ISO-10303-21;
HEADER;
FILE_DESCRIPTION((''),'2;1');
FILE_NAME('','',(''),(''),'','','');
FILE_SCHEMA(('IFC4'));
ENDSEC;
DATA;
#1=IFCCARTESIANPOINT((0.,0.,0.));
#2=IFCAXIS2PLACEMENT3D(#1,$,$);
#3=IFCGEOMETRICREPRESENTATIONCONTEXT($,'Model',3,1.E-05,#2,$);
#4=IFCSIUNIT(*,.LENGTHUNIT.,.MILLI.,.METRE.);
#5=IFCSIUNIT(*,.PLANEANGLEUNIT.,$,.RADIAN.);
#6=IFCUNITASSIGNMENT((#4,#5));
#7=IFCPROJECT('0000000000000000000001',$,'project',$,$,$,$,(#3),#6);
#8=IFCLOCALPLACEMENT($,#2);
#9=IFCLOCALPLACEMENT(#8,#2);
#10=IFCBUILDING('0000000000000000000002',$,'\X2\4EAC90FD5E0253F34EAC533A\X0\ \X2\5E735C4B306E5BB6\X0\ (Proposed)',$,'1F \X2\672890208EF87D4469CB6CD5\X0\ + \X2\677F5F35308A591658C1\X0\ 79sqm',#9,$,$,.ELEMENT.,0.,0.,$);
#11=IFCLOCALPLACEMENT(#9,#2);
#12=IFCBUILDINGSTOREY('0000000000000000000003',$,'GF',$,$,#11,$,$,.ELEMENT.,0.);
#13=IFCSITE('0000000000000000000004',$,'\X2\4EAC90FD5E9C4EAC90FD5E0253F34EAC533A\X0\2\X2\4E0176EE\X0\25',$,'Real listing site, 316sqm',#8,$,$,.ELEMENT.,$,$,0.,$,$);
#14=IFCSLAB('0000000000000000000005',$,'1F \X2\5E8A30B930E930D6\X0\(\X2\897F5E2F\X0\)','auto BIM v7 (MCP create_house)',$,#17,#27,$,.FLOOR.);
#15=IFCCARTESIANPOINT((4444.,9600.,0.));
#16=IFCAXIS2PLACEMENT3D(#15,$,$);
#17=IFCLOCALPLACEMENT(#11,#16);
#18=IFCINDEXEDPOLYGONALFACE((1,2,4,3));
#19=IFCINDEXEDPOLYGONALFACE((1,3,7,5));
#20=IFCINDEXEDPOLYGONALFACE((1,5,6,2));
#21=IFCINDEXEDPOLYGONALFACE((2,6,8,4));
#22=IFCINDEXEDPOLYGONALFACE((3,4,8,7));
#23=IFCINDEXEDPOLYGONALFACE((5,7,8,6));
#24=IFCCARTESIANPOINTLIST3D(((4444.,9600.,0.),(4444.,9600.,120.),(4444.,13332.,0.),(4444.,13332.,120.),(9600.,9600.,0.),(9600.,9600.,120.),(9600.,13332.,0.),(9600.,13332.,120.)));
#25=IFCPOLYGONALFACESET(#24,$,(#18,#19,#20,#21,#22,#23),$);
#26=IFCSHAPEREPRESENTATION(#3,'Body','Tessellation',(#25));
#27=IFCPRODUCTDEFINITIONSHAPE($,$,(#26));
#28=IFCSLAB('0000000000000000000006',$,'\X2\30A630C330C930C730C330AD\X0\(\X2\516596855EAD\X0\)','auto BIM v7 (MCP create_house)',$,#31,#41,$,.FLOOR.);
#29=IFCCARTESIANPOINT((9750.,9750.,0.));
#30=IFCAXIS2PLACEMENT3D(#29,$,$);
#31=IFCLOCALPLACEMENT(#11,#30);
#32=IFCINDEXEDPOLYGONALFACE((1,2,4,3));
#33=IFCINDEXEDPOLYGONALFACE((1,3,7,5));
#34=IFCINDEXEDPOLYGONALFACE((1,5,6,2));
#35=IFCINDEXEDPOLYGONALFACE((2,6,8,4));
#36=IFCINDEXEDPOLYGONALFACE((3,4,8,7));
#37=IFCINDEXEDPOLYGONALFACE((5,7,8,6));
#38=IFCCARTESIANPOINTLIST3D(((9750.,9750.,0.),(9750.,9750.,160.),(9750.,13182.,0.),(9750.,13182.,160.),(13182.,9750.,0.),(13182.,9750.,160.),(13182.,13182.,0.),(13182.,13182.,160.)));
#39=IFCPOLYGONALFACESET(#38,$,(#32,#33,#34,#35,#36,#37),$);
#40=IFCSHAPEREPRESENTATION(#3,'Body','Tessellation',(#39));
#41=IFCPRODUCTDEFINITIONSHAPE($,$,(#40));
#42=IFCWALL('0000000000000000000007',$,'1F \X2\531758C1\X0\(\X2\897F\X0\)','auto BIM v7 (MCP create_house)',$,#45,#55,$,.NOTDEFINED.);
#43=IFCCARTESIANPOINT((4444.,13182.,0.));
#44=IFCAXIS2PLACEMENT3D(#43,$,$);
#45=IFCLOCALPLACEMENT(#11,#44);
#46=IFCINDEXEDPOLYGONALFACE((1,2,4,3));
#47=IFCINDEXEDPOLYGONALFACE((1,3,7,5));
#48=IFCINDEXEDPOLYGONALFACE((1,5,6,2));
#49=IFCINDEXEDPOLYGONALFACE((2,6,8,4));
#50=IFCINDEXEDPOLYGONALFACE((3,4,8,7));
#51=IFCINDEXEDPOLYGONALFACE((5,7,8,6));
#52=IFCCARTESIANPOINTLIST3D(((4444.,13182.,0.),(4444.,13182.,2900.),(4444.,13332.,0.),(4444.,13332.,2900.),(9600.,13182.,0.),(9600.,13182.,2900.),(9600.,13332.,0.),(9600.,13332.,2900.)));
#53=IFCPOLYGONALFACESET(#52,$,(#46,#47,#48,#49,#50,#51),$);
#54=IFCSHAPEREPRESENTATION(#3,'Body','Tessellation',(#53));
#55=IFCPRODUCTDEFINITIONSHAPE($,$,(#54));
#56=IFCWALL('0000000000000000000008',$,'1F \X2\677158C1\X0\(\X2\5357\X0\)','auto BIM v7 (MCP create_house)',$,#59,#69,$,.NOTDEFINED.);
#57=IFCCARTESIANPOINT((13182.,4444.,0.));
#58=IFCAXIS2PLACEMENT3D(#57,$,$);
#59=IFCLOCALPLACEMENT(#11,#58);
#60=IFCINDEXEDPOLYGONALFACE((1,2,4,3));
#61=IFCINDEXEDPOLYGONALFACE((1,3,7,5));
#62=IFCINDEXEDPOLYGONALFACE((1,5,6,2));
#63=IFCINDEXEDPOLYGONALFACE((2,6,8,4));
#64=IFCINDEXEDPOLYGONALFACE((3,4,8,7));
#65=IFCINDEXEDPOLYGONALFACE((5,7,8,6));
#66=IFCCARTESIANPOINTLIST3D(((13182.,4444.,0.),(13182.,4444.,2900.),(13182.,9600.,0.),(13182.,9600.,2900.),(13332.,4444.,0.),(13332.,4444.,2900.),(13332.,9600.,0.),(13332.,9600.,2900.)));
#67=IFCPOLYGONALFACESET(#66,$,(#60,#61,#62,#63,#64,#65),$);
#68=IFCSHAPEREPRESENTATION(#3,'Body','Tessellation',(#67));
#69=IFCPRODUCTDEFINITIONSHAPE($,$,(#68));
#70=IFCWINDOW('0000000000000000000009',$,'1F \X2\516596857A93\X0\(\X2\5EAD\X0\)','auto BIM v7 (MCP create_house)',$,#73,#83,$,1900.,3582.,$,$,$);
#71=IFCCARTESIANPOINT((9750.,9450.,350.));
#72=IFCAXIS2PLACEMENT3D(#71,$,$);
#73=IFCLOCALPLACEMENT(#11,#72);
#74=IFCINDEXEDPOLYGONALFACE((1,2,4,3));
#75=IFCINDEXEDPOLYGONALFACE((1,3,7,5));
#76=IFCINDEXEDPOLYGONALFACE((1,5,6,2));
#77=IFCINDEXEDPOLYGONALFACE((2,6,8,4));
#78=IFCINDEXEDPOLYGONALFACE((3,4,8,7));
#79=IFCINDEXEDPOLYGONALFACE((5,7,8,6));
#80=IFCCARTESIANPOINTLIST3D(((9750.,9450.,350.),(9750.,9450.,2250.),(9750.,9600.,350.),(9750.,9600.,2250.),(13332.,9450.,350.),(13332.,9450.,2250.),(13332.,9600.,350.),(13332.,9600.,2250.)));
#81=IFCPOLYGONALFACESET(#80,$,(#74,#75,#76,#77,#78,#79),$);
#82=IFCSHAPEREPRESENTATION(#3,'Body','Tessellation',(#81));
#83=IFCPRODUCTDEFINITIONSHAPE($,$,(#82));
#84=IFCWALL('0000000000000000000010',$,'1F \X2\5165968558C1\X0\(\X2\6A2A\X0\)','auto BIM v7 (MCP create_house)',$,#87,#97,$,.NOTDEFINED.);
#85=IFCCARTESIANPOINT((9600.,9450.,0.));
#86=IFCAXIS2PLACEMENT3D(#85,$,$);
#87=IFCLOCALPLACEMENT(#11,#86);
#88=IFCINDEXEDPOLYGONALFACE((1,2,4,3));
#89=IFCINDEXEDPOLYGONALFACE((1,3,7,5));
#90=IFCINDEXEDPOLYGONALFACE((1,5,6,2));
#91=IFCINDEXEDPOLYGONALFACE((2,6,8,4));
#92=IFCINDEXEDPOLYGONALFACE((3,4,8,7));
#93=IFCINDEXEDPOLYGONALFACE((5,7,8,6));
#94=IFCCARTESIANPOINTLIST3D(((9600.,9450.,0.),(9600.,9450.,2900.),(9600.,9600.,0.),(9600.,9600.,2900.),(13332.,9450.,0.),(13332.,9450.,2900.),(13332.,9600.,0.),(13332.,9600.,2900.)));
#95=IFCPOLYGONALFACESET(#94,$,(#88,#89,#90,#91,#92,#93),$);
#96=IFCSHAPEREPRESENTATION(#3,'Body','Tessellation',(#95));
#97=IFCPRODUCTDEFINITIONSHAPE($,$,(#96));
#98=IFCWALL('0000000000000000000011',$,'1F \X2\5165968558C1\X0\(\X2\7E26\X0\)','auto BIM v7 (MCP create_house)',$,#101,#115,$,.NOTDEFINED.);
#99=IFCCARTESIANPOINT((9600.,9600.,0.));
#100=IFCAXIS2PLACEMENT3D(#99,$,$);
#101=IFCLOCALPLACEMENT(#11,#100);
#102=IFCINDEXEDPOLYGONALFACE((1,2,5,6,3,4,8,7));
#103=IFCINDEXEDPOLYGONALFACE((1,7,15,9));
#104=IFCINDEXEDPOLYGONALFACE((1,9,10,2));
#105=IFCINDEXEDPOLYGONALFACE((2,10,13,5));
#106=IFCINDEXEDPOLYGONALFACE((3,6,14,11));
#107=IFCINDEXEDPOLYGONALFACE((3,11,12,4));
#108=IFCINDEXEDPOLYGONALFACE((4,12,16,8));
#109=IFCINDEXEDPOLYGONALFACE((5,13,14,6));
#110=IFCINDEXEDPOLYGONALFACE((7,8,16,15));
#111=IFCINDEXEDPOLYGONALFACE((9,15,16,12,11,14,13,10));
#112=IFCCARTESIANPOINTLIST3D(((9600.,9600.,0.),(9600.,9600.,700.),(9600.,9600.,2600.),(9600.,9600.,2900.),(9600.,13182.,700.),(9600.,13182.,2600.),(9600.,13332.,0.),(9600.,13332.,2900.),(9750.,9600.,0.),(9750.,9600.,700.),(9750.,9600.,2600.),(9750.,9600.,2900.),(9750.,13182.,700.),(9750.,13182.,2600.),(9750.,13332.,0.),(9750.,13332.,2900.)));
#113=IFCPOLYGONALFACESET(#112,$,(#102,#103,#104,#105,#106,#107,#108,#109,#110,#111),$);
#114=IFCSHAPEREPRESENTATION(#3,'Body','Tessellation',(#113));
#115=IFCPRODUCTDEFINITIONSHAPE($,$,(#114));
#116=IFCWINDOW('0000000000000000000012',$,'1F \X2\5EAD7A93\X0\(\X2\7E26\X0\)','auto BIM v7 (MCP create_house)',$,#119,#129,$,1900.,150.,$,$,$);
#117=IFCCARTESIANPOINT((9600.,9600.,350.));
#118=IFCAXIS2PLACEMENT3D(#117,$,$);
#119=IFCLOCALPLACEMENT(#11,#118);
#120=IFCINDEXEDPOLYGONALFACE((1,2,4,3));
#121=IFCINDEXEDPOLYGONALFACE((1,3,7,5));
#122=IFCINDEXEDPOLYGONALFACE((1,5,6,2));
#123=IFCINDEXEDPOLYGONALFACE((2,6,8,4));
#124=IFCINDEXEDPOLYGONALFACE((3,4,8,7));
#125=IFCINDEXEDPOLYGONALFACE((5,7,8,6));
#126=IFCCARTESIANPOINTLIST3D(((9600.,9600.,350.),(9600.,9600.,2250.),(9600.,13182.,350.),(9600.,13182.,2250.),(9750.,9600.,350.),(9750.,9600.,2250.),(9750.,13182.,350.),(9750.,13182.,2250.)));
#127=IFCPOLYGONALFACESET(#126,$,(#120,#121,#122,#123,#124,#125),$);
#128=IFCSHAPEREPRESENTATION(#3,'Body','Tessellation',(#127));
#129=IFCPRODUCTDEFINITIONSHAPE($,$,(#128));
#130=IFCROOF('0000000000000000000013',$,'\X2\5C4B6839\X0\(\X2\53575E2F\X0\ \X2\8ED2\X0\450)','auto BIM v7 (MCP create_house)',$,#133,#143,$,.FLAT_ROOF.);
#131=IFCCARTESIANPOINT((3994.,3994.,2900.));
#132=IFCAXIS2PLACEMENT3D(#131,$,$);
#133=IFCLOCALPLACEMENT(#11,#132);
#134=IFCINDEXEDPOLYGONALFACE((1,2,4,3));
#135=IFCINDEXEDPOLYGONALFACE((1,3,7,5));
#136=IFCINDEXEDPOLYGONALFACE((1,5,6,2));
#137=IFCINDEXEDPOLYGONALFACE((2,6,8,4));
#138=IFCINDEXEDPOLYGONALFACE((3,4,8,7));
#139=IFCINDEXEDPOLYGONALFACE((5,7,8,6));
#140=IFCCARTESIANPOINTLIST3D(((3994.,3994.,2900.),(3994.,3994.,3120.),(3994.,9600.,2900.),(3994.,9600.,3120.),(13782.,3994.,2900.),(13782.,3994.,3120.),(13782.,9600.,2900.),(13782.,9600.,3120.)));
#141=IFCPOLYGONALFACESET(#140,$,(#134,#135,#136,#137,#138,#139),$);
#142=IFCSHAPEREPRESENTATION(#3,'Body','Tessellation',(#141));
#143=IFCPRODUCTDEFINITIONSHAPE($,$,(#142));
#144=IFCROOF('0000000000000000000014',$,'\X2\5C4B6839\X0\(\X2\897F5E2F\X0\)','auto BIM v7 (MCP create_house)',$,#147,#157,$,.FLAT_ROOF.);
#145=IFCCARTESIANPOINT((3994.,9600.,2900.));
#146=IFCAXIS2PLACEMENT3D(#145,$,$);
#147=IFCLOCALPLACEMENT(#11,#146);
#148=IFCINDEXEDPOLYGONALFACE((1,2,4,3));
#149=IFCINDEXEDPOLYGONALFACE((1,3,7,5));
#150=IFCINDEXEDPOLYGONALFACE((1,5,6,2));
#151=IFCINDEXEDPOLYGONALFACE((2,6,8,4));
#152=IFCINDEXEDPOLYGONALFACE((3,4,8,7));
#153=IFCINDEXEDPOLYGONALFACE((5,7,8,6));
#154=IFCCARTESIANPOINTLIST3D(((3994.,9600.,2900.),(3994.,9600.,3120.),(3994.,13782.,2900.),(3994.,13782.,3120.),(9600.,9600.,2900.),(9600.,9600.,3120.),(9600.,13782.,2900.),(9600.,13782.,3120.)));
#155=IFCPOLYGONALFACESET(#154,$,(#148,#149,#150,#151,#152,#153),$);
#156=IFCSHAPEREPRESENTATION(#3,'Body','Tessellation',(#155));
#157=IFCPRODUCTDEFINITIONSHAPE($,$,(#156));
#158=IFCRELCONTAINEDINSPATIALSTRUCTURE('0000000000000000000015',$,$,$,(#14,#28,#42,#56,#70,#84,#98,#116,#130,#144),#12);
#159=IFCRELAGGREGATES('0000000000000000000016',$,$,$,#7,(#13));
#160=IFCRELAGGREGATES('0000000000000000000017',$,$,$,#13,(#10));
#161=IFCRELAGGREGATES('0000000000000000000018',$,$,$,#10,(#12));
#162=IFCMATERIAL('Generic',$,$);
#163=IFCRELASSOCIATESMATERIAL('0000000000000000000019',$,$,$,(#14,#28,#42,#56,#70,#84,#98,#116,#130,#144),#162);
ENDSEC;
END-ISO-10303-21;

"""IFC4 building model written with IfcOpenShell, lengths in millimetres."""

from ifc_helpers import new_model, si_unit, frame, frame_2d, origin, place, context, project, spatial, rectangle, extrude, material, element, fill, save


model = new_model("IFC4")

# Units and contexts
model_context = context("Model", 3, precision=1e-05, world=origin())
ifc_project = project(units=[si_unit("LENGTHUNIT", "METRE", prefix="MILLI"), si_unit("PLANEANGLEUNIT", "RADIAN")], contexts=[model_context])

# Site, building, storey
site_placement = place(None, origin())
site = spatial("IfcSite", under=ifc_project, at=site_placement, Name="京都府京都市右京区2丁目25", ObjectType="Real listing site, 316sqm", CompositionType="ELEMENT", RefElevation=0.0)
building_placement = place(site_placement, origin())
building = spatial("IfcBuilding", under=site, at=building_placement, Name="京都市右京区 平屋の家 (Proposed)", ObjectType="1F 木造軸組構法 + 板張り外壁 79sqm", CompositionType="ELEMENT", ElevationOfRefHeight=0.0, ElevationOfTerrain=0.0)
storey_placement = place(building_placement, origin())
storey = spatial("IfcBuildingStorey", under=building, at=storey_placement, Name="GF", CompositionType="ELEMENT", Elevation=0.0)

# Slabs
ifc_material = material(Name="Generic")
slab_1_placement = place(storey_placement, frame((4444.0, 9600.0, 0.0)))
element("IfcSlab", 1, at=slab_1_placement, inside=storey, material=ifc_material, Name="1F 床スラブ(西帯)", Description="auto BIM v7 (MCP create_house)", PredefinedType="FLOOR", context=model_context, shape_type="SweptSolid", body=[
    extrude(rectangle(XDim=5156.0, YDim=3732.0, at=frame_2d((2578.0, 1866.0))), frame((4444.0, 9600.0, 0.0)), (0.0, 0.0, 1.0), 120.0),
])
slab_2_placement = place(storey_placement, frame((9750.0, 9750.0, 0.0)))
element("IfcSlab", 2, at=slab_2_placement, inside=storey, material=ifc_material, Name="ウッドデッキ(入隅庭)", Description="auto BIM v7 (MCP create_house)", PredefinedType="FLOOR", context=model_context, shape_type="SweptSolid", body=[
    extrude(rectangle(XDim=3432.0, YDim=3432.0, at=frame_2d((1716.0, 1716.0))), frame((9750.0, 9750.0, 0.0)), (0.0, 0.0, 1.0), 160.0),
])

# Wall
wall_1_placement = place(storey_placement, frame((4444.0, 13182.0, 0.0)))
element("IfcWall", 3, at=wall_1_placement, inside=storey, material=ifc_material, Name="1F 北壁(西)", Description="auto BIM v7 (MCP create_house)", PredefinedType="NOTDEFINED", context=model_context, shape_type="SweptSolid", body=[
    extrude(rectangle(XDim=5156.0, YDim=150.0, at=frame_2d((2578.0, 75.0))), frame((4444.0, 13182.0, 0.0)), (0.0, 0.0, 1.0), 2900.0),
])

# Wall, opening, window
wall_2_placement = place(storey_placement, frame((13182.0, 4444.0, 0.0)))
wall_2 = element("IfcWall", 4, at=wall_2_placement, inside=storey, material=ifc_material, Name="1F 東壁(南)", Description="auto BIM v7 (MCP create_house)", PredefinedType="NOTDEFINED", context=model_context, shape_type="SweptSolid", body=[
    extrude(rectangle(XDim=150.0, YDim=5156.0, at=frame_2d((75.0, 2578.0))), frame((13182.0, 4444.0, 0.0)), (0.0, 0.0, 1.0), 2900.0),
])
opening_1_placement = place(storey_placement, frame((9750.0, 9450.0, 350.0)))
opening_1 = element("IfcOpeningElement", 5, at=opening_1_placement, cuts=wall_2, PredefinedType="NOTDEFINED", context=model_context, shape_type="SweptSolid", body=[
    extrude(rectangle(XDim=3582.0, YDim=150.0, at=frame_2d((1791.0, 75.0))), frame((9750.0, 9450.0, 350.0)), (0.0, 0.0, 1.0), 1900.0),
])
window_1_placement = place(storey_placement, frame((9750.0, 9450.0, 350.0)))
window_1 = element("IfcWindow", 6, at=window_1_placement, inside=storey, material=ifc_material, Name="1F 入隅窓(庭)", Description="auto BIM v7 (MCP create_house)", OverallHeight=1900.0, OverallWidth=3582.0, context=model_context, shape_type="SweptSolid", body=[
    extrude(rectangle(XDim=3582.0, YDim=150.0, at=frame_2d((1791.0, 75.0))), frame((9750.0, 9450.0, 350.0)), (0.0, 0.0, 1.0), 1900.0),
])
fill(opening_1, window_1)

# Wall
wall_3_placement = place(storey_placement, frame((9600.0, 9450.0, 0.0)))
element("IfcWall", 7, at=wall_3_placement, inside=storey, material=ifc_material, Name="1F 入隅壁(横)", Description="auto BIM v7 (MCP create_house)", PredefinedType="NOTDEFINED", context=model_context, shape_type="SweptSolid", body=[
    extrude(rectangle(XDim=3732.0, YDim=150.0, at=frame_2d((1866.0, 75.0))), frame((9600.0, 9450.0, 0.0)), (0.0, 0.0, 1.0), 2900.0),
])

# Wall, opening, window
wall_4_placement = place(storey_placement, frame((9600.0, 9600.0, 0.0)))
wall_4 = element("IfcWall", 8, at=wall_4_placement, inside=storey, material=ifc_material, Name="1F 入隅壁(縦)", Description="auto BIM v7 (MCP create_house)", PredefinedType="NOTDEFINED", context=model_context, shape_type="SweptSolid", body=[
    extrude(rectangle(XDim=150.0, YDim=3732.0, at=frame_2d((75.0, 1866.0))), frame((9600.0, 9600.0, 0.0)), (0.0, 0.0, 1.0), 2900.0),
])
opening_2_placement = place(storey_placement, frame((9600.0, 9600.0, 350.0)))
opening_2 = element("IfcOpeningElement", 9, at=opening_2_placement, cuts=wall_4, PredefinedType="NOTDEFINED", context=model_context, shape_type="SweptSolid", body=[
    extrude(rectangle(XDim=150.0, YDim=3582.0, at=frame_2d((75.0, 1791.0))), frame((9600.0, 9600.0, 350.0)), (0.0, 0.0, 1.0), 1900.0),
])
window_2_placement = place(storey_placement, frame((9600.0, 9600.0, 350.0)))
window_2 = element("IfcWindow", 10, at=window_2_placement, inside=storey, material=ifc_material, Name="1F 庭窓(縦)", Description="auto BIM v7 (MCP create_house)", OverallHeight=1900.0, OverallWidth=150.0, context=model_context, shape_type="SweptSolid", body=[
    extrude(rectangle(XDim=150.0, YDim=3582.0, at=frame_2d((75.0, 1791.0))), frame((9600.0, 9600.0, 350.0)), (0.0, 0.0, 1.0), 1900.0),
])
fill(opening_2, window_2)

# Roofs
roof_1_placement = place(storey_placement, frame((3994.0, 3994.0, 2900.0)))
element("IfcRoof", 11, at=roof_1_placement, inside=storey, material=ifc_material, Name="屋根(南帯 軒450)", Description="auto BIM v7 (MCP create_house)", PredefinedType="FLAT_ROOF", context=model_context, shape_type="SweptSolid", body=[
    extrude(rectangle(XDim=9788.0, YDim=5606.0, at=frame_2d((4894.0, 2803.0))), frame((3994.0, 3994.0, 2900.0)), (0.0, 0.0, 1.0), 220.0),
])
roof_2_placement = place(storey_placement, frame((3994.0, 9600.0, 2900.0)))
element("IfcRoof", 12, at=roof_2_placement, inside=storey, material=ifc_material, Name="屋根(西帯)", Description="auto BIM v7 (MCP create_house)", PredefinedType="FLAT_ROOF", context=model_context, shape_type="SweptSolid", body=[
    extrude(rectangle(XDim=5606.0, YDim=4182.0, at=frame_2d((2803.0, 2091.0))), frame((3994.0, 9600.0, 2900.0)), (0.0, 0.0, 1.0), 220.0),
])

save(model, "model.ifc")
